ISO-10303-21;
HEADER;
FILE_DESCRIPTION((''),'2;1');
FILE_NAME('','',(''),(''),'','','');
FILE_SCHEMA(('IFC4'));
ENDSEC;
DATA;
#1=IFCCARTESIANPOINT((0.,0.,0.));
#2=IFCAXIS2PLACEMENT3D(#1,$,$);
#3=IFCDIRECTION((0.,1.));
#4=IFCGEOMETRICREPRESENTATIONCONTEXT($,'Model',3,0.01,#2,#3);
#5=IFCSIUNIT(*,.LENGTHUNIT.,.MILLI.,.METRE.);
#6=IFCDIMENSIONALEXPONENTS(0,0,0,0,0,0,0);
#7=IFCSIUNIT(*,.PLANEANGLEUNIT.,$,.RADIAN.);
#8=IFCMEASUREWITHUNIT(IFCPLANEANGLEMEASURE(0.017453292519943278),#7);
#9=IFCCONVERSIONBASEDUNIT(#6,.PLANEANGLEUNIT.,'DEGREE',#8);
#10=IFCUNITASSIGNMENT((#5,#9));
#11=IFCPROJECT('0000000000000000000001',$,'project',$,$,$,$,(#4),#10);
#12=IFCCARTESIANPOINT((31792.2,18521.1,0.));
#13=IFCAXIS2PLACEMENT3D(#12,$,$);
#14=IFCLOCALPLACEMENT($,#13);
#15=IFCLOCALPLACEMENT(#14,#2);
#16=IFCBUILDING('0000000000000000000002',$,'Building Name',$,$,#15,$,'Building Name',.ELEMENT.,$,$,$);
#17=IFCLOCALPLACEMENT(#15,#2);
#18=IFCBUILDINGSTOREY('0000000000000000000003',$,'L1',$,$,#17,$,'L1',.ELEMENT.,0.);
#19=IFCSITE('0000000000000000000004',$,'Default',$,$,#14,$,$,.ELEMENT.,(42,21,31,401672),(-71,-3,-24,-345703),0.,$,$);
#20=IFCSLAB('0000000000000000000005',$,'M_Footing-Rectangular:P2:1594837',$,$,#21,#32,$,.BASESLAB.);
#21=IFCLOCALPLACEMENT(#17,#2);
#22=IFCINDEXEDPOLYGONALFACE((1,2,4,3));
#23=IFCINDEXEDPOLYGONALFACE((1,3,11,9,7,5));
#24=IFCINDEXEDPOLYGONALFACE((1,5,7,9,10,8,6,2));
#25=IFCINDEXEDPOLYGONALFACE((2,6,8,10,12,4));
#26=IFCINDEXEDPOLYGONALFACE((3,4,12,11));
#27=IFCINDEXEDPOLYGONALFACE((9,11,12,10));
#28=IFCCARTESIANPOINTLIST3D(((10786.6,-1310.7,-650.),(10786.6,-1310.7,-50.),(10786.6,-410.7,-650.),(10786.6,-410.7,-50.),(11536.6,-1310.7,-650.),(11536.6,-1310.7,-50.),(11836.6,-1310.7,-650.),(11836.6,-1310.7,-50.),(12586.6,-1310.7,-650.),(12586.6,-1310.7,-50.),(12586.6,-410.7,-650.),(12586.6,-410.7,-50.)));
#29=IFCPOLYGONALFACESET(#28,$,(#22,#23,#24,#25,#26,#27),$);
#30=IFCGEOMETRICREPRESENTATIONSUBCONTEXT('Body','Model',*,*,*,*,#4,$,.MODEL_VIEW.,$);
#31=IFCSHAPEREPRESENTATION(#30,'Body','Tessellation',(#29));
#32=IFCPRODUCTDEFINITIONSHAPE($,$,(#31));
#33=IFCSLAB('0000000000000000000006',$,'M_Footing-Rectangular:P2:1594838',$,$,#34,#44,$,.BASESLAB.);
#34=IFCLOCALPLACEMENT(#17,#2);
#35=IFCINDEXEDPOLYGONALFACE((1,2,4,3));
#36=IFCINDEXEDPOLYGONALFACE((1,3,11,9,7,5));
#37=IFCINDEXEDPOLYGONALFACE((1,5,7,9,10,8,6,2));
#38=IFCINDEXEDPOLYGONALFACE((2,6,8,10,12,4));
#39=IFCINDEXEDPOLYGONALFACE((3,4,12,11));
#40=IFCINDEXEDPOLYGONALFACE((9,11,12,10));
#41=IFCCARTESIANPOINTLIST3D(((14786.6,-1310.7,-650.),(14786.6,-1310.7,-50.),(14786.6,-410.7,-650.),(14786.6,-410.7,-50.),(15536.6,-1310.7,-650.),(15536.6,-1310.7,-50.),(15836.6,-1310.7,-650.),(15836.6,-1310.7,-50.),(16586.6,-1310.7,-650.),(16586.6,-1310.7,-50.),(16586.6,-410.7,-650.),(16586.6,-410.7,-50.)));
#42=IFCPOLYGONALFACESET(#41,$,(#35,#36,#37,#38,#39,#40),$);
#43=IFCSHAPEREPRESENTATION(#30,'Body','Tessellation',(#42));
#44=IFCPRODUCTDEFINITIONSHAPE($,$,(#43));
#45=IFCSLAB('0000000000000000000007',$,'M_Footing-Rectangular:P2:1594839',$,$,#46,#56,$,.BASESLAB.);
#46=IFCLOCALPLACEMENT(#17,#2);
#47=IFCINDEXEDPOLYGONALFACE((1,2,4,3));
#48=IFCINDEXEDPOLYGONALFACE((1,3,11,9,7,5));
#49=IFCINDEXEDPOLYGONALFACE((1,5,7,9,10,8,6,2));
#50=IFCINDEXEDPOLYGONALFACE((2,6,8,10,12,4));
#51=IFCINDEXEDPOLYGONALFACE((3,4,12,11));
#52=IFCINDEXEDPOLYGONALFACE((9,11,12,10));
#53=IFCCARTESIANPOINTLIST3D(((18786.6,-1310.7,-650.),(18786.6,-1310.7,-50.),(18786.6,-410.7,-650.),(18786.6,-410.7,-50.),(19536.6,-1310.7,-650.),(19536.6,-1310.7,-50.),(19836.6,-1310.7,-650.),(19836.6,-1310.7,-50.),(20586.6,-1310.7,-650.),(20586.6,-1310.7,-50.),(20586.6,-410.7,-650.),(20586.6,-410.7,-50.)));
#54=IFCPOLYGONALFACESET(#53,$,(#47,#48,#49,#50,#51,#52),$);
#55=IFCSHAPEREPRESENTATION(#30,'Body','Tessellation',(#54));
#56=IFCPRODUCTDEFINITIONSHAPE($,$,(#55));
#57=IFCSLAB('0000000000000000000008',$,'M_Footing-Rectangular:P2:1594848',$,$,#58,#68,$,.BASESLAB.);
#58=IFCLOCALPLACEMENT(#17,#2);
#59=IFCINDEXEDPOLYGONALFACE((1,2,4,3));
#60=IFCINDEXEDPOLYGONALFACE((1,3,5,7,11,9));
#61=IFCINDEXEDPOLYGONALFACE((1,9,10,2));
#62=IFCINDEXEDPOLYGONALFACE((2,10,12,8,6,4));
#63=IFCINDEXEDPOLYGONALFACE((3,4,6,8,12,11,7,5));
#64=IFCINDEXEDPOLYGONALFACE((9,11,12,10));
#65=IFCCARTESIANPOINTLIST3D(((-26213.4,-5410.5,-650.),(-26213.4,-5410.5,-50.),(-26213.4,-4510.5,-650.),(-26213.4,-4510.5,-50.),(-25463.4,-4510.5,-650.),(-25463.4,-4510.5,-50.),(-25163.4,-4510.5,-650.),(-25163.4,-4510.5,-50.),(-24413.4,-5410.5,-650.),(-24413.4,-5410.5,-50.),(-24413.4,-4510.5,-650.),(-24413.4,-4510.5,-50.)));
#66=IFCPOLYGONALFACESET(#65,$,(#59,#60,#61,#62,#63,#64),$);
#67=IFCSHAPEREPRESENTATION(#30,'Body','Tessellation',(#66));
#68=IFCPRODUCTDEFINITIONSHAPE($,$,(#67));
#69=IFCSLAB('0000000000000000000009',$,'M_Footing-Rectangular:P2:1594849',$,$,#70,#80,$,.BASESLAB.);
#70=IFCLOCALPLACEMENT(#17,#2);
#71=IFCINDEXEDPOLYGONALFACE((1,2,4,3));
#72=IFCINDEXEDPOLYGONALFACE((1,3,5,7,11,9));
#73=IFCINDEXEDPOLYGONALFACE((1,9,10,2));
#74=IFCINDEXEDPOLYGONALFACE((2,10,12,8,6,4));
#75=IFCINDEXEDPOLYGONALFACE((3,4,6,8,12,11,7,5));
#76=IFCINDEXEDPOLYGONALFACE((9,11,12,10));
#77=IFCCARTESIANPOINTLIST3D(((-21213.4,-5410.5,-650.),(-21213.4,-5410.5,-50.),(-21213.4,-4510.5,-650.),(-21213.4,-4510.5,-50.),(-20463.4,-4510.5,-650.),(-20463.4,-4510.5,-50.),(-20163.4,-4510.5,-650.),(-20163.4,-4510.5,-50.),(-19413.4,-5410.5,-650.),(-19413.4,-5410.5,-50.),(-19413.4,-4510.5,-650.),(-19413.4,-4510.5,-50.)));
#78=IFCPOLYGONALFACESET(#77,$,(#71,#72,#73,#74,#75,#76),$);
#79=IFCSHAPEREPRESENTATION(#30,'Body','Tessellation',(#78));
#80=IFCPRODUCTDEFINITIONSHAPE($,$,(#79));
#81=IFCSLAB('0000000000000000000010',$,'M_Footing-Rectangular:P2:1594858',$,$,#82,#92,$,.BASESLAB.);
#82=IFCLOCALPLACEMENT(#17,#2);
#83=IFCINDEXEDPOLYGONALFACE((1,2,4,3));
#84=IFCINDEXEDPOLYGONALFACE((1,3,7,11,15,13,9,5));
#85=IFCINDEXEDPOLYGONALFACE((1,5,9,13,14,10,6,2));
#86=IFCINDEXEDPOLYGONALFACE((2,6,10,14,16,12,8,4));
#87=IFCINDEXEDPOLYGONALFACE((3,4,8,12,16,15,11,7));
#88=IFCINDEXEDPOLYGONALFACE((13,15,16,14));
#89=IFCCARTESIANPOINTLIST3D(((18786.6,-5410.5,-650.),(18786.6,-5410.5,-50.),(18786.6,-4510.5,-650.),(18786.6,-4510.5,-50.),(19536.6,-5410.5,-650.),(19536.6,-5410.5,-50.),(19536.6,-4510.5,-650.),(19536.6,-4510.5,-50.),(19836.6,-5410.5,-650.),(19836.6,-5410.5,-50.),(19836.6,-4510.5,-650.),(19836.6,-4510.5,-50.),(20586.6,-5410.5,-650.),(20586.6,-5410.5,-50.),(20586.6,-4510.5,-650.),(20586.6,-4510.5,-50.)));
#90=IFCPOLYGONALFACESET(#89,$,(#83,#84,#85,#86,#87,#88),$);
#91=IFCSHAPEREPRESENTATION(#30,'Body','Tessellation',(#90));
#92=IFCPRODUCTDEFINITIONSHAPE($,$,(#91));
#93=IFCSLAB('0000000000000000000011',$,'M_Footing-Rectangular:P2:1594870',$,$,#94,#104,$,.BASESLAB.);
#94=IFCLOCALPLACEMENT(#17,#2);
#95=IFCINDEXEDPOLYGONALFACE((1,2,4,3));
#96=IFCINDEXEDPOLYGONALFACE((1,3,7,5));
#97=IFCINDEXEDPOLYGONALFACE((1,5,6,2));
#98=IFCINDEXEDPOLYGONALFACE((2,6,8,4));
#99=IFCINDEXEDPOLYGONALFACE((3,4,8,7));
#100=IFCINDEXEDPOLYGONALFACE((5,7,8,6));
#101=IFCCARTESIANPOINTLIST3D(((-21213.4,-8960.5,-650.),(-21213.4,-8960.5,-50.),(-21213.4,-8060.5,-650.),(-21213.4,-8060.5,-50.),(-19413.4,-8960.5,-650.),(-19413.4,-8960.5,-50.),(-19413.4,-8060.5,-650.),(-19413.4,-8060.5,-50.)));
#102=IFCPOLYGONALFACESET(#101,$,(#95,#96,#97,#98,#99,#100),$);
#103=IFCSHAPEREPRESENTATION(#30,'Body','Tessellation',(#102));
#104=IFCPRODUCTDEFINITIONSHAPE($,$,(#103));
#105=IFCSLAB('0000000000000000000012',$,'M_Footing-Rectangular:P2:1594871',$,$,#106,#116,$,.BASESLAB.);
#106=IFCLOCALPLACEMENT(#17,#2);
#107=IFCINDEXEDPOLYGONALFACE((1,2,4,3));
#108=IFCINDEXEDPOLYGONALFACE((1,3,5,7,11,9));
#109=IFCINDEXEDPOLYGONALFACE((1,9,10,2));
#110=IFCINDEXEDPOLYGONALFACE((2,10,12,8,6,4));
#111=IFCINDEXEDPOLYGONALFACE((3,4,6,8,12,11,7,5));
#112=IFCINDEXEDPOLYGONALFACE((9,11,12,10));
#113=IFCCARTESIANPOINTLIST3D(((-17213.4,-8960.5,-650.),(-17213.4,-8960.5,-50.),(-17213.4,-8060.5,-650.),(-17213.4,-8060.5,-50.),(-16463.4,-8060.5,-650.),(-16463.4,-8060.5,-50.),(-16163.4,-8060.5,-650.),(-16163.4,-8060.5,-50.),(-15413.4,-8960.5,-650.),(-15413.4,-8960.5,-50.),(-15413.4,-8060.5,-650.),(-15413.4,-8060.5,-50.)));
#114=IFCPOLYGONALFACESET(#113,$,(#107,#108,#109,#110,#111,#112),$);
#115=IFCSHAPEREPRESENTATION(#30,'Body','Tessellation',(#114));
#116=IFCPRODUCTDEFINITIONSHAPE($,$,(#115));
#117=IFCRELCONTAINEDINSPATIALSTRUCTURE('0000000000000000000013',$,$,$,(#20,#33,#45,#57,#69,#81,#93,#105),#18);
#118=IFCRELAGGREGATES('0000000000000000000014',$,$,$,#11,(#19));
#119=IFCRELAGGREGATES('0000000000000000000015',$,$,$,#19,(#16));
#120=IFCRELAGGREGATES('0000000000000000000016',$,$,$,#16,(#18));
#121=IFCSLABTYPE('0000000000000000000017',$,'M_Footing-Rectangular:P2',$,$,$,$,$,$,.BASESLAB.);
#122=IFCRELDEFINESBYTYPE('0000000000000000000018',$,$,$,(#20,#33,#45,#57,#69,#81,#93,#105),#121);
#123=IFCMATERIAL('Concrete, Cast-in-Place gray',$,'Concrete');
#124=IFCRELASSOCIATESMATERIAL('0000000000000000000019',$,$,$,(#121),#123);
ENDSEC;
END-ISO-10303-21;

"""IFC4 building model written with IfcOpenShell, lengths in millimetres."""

from ifc_helpers import new_model, entity, si_unit, converted_unit, direction, frame, origin, place, context, subcontext, project, spatial, indexed_curve, outline, extrude, material, type_object, element, save


model = new_model("IFC4")

# Units and contexts
model_context = context("Model", 3, precision=0.01, world=origin(), true_north=direction((0.0, 1.0)))
body_context = subcontext(model_context, "Body", "Model", "MODEL_VIEW")
ifc_project = project(units=[si_unit("LENGTHUNIT", "METRE", prefix="MILLI"), converted_unit("PLANEANGLEUNIT", "DEGREE", entity("IfcPlaneAngleMeasure", 0.017453292519943278), si_unit("PLANEANGLEUNIT", "RADIAN"), dimensions=[0, 0, 0, 0, 0, 0, 0])], contexts=[model_context])

# Site, building, storey
site_placement = place(None, frame((31792.2, 18521.1, 0.0)))
site = spatial("IfcSite", under=ifc_project, at=site_placement, Name="Default", CompositionType="ELEMENT", RefLatitude=(42, 21, 31, 401672), RefLongitude=(-71, -3, -24, -345703), RefElevation=0.0)
building_placement = place(site_placement, origin())
building = spatial("IfcBuilding", under=site, at=building_placement, Name="Building Name", LongName="Building Name", CompositionType="ELEMENT")
storey_placement = place(building_placement, origin())
storey = spatial("IfcBuildingStorey", under=building, at=storey_placement, Name="L1", LongName="L1", CompositionType="ELEMENT", Elevation=0.0)

# Slabs
ifc_material = material(Name="Concrete, Cast-in-Place gray", Category="Concrete")
slab_type = type_object("IfcSlabType", Name="M_Footing-Rectangular:P2", PredefinedType="BASESLAB", material=ifc_material)
slab_1_placement = place(storey_placement, origin())
element("IfcSlab", 1, at=slab_1_placement, inside=storey, type_object=slab_type, Name="M_Footing-Rectangular:P2:1594837", PredefinedType="BASESLAB", context=body_context, shape_type="SweptSolid", body=[
    extrude(outline(indexed_curve([(-600.0, -900.0), (300.0, -900.0), (300.0, -150.0), (300.0, 150.0), (300.0, 900.0), (-600.0, 900.0), (-600.0, -900.0)], self_intersect=False)), frame((11686.6, -1010.7, -650.0), z_axis=(0.0, 0.0, 1.0), x_axis=(0.0, -1.0, 0.0)), (0.0, 0.0, 1.0), 600.0),
])
slab_2_placement = place(storey_placement, origin())
element("IfcSlab", 2, at=slab_2_placement, inside=storey, type_object=slab_type, Name="M_Footing-Rectangular:P2:1594838", PredefinedType="BASESLAB", context=body_context, shape_type="SweptSolid", body=[
    extrude(outline(indexed_curve([(-600.0, -900.0), (300.0, -900.0), (300.0, -150.0), (300.0, 150.0), (300.0, 900.0), (-600.0, 900.0), (-600.0, -900.0)], self_intersect=False)), frame((15686.6, -1010.7, -650.0), z_axis=(0.0, 0.0, 1.0), x_axis=(0.0, -1.0, 0.0)), (0.0, 0.0, 1.0), 600.0),
])
slab_3_placement = place(storey_placement, origin())
element("IfcSlab", 3, at=slab_3_placement, inside=storey, type_object=slab_type, Name="M_Footing-Rectangular:P2:1594839", PredefinedType="BASESLAB", context=body_context, shape_type="SweptSolid", body=[
    extrude(outline(indexed_curve([(-600.0, -900.0), (300.0, -900.0), (300.0, -150.0), (300.0, 150.0), (300.0, 900.0), (-600.0, 900.0), (-600.0, -900.0)], self_intersect=False)), frame((19686.6, -1010.7, -650.0), z_axis=(0.0, 0.0, 1.0), x_axis=(0.0, -1.0, 0.0)), (0.0, 0.0, 1.0), 600.0),
])
slab_4_placement = place(storey_placement, origin())
element("IfcSlab", 4, at=slab_4_placement, inside=storey, type_object=slab_type, Name="M_Footing-Rectangular:P2:1594848", PredefinedType="BASESLAB", context=body_context, shape_type="SweptSolid", body=[
    extrude(outline(indexed_curve([(-300.0, -900.0), (600.0, -900.0), (600.0, 900.0), (-300.0, 900.0), (-300.0, 150.0), (-300.0, -150.0), (-300.0, -900.0)], self_intersect=False)), frame((-25313.4, -4810.5, -650.0), z_axis=(0.0, 0.0, 1.0), x_axis=(0.0, -1.0, 0.0)), (0.0, 0.0, 1.0), 600.0),
])
slab_5_placement = place(storey_placement, origin())
element("IfcSlab", 5, at=slab_5_placement, inside=storey, type_object=slab_type, Name="M_Footing-Rectangular:P2:1594849", PredefinedType="BASESLAB", context=body_context, shape_type="SweptSolid", body=[
    extrude(outline(indexed_curve([(-300.0, -900.0), (600.0, -900.0), (600.0, 900.0), (-300.0, 900.0), (-300.0, 150.0), (-300.0, -150.0), (-300.0, -900.0)], self_intersect=False)), frame((-20313.4, -4810.5, -650.0), z_axis=(0.0, 0.0, 1.0), x_axis=(0.0, -1.0, 0.0)), (0.0, 0.0, 1.0), 600.0),
])
slab_6_placement = place(storey_placement, origin())
element("IfcSlab", 6, at=slab_6_placement, inside=storey, type_object=slab_type, Name="M_Footing-Rectangular:P2:1594858", PredefinedType="BASESLAB", context=body_context, shape_type="SweptSolid", body=[
    extrude(outline(indexed_curve([(-450.0, -900.0), (450.0, -900.0), (450.0, -150.0), (450.0, 150.0), (450.0, 900.0), (-450.0, 900.0), (-450.0, 150.0), (-450.0, -150.0), (-450.0, -900.0)], self_intersect=False)), frame((19686.6, -4960.5, -650.0), z_axis=(0.0, 0.0, 1.0), x_axis=(0.0, -1.0, 0.0)), (0.0, 0.0, 1.0), 600.0),
])
slab_7_placement = place(storey_placement, origin())
element("IfcSlab", 7, at=slab_7_placement, inside=storey, type_object=slab_type, Name="M_Footing-Rectangular:P2:1594870", PredefinedType="BASESLAB", context=body_context, shape_type="SweptSolid", body=[
    extrude(outline(indexed_curve([(-450.0, -900.0), (450.0, -900.0), (450.0, 900.0), (-450.0, 900.0), (-450.0, -900.0)], self_intersect=False)), frame((-20313.4, -8510.5, -650.0), z_axis=(0.0, 0.0, 1.0), x_axis=(0.0, -1.0, 0.0)), (0.0, 0.0, 1.0), 600.0),
])
slab_8_placement = place(storey_placement, origin())
element("IfcSlab", 8, at=slab_8_placement, inside=storey, type_object=slab_type, Name="M_Footing-Rectangular:P2:1594871", PredefinedType="BASESLAB", context=body_context, shape_type="SweptSolid", body=[
    extrude(outline(indexed_curve([(-300.0, -900.0), (600.0, -900.0), (600.0, 900.0), (-300.0, 900.0), (-300.0, 150.0), (-300.0, -150.0), (-300.0, -900.0)], self_intersect=False)), frame((-16313.4, -8360.5, -650.0), z_axis=(0.0, 0.0, 1.0), x_axis=(0.0, -1.0, 0.0)), (0.0, 0.0, 1.0), 600.0),
])

save(model, "model.ifc")
